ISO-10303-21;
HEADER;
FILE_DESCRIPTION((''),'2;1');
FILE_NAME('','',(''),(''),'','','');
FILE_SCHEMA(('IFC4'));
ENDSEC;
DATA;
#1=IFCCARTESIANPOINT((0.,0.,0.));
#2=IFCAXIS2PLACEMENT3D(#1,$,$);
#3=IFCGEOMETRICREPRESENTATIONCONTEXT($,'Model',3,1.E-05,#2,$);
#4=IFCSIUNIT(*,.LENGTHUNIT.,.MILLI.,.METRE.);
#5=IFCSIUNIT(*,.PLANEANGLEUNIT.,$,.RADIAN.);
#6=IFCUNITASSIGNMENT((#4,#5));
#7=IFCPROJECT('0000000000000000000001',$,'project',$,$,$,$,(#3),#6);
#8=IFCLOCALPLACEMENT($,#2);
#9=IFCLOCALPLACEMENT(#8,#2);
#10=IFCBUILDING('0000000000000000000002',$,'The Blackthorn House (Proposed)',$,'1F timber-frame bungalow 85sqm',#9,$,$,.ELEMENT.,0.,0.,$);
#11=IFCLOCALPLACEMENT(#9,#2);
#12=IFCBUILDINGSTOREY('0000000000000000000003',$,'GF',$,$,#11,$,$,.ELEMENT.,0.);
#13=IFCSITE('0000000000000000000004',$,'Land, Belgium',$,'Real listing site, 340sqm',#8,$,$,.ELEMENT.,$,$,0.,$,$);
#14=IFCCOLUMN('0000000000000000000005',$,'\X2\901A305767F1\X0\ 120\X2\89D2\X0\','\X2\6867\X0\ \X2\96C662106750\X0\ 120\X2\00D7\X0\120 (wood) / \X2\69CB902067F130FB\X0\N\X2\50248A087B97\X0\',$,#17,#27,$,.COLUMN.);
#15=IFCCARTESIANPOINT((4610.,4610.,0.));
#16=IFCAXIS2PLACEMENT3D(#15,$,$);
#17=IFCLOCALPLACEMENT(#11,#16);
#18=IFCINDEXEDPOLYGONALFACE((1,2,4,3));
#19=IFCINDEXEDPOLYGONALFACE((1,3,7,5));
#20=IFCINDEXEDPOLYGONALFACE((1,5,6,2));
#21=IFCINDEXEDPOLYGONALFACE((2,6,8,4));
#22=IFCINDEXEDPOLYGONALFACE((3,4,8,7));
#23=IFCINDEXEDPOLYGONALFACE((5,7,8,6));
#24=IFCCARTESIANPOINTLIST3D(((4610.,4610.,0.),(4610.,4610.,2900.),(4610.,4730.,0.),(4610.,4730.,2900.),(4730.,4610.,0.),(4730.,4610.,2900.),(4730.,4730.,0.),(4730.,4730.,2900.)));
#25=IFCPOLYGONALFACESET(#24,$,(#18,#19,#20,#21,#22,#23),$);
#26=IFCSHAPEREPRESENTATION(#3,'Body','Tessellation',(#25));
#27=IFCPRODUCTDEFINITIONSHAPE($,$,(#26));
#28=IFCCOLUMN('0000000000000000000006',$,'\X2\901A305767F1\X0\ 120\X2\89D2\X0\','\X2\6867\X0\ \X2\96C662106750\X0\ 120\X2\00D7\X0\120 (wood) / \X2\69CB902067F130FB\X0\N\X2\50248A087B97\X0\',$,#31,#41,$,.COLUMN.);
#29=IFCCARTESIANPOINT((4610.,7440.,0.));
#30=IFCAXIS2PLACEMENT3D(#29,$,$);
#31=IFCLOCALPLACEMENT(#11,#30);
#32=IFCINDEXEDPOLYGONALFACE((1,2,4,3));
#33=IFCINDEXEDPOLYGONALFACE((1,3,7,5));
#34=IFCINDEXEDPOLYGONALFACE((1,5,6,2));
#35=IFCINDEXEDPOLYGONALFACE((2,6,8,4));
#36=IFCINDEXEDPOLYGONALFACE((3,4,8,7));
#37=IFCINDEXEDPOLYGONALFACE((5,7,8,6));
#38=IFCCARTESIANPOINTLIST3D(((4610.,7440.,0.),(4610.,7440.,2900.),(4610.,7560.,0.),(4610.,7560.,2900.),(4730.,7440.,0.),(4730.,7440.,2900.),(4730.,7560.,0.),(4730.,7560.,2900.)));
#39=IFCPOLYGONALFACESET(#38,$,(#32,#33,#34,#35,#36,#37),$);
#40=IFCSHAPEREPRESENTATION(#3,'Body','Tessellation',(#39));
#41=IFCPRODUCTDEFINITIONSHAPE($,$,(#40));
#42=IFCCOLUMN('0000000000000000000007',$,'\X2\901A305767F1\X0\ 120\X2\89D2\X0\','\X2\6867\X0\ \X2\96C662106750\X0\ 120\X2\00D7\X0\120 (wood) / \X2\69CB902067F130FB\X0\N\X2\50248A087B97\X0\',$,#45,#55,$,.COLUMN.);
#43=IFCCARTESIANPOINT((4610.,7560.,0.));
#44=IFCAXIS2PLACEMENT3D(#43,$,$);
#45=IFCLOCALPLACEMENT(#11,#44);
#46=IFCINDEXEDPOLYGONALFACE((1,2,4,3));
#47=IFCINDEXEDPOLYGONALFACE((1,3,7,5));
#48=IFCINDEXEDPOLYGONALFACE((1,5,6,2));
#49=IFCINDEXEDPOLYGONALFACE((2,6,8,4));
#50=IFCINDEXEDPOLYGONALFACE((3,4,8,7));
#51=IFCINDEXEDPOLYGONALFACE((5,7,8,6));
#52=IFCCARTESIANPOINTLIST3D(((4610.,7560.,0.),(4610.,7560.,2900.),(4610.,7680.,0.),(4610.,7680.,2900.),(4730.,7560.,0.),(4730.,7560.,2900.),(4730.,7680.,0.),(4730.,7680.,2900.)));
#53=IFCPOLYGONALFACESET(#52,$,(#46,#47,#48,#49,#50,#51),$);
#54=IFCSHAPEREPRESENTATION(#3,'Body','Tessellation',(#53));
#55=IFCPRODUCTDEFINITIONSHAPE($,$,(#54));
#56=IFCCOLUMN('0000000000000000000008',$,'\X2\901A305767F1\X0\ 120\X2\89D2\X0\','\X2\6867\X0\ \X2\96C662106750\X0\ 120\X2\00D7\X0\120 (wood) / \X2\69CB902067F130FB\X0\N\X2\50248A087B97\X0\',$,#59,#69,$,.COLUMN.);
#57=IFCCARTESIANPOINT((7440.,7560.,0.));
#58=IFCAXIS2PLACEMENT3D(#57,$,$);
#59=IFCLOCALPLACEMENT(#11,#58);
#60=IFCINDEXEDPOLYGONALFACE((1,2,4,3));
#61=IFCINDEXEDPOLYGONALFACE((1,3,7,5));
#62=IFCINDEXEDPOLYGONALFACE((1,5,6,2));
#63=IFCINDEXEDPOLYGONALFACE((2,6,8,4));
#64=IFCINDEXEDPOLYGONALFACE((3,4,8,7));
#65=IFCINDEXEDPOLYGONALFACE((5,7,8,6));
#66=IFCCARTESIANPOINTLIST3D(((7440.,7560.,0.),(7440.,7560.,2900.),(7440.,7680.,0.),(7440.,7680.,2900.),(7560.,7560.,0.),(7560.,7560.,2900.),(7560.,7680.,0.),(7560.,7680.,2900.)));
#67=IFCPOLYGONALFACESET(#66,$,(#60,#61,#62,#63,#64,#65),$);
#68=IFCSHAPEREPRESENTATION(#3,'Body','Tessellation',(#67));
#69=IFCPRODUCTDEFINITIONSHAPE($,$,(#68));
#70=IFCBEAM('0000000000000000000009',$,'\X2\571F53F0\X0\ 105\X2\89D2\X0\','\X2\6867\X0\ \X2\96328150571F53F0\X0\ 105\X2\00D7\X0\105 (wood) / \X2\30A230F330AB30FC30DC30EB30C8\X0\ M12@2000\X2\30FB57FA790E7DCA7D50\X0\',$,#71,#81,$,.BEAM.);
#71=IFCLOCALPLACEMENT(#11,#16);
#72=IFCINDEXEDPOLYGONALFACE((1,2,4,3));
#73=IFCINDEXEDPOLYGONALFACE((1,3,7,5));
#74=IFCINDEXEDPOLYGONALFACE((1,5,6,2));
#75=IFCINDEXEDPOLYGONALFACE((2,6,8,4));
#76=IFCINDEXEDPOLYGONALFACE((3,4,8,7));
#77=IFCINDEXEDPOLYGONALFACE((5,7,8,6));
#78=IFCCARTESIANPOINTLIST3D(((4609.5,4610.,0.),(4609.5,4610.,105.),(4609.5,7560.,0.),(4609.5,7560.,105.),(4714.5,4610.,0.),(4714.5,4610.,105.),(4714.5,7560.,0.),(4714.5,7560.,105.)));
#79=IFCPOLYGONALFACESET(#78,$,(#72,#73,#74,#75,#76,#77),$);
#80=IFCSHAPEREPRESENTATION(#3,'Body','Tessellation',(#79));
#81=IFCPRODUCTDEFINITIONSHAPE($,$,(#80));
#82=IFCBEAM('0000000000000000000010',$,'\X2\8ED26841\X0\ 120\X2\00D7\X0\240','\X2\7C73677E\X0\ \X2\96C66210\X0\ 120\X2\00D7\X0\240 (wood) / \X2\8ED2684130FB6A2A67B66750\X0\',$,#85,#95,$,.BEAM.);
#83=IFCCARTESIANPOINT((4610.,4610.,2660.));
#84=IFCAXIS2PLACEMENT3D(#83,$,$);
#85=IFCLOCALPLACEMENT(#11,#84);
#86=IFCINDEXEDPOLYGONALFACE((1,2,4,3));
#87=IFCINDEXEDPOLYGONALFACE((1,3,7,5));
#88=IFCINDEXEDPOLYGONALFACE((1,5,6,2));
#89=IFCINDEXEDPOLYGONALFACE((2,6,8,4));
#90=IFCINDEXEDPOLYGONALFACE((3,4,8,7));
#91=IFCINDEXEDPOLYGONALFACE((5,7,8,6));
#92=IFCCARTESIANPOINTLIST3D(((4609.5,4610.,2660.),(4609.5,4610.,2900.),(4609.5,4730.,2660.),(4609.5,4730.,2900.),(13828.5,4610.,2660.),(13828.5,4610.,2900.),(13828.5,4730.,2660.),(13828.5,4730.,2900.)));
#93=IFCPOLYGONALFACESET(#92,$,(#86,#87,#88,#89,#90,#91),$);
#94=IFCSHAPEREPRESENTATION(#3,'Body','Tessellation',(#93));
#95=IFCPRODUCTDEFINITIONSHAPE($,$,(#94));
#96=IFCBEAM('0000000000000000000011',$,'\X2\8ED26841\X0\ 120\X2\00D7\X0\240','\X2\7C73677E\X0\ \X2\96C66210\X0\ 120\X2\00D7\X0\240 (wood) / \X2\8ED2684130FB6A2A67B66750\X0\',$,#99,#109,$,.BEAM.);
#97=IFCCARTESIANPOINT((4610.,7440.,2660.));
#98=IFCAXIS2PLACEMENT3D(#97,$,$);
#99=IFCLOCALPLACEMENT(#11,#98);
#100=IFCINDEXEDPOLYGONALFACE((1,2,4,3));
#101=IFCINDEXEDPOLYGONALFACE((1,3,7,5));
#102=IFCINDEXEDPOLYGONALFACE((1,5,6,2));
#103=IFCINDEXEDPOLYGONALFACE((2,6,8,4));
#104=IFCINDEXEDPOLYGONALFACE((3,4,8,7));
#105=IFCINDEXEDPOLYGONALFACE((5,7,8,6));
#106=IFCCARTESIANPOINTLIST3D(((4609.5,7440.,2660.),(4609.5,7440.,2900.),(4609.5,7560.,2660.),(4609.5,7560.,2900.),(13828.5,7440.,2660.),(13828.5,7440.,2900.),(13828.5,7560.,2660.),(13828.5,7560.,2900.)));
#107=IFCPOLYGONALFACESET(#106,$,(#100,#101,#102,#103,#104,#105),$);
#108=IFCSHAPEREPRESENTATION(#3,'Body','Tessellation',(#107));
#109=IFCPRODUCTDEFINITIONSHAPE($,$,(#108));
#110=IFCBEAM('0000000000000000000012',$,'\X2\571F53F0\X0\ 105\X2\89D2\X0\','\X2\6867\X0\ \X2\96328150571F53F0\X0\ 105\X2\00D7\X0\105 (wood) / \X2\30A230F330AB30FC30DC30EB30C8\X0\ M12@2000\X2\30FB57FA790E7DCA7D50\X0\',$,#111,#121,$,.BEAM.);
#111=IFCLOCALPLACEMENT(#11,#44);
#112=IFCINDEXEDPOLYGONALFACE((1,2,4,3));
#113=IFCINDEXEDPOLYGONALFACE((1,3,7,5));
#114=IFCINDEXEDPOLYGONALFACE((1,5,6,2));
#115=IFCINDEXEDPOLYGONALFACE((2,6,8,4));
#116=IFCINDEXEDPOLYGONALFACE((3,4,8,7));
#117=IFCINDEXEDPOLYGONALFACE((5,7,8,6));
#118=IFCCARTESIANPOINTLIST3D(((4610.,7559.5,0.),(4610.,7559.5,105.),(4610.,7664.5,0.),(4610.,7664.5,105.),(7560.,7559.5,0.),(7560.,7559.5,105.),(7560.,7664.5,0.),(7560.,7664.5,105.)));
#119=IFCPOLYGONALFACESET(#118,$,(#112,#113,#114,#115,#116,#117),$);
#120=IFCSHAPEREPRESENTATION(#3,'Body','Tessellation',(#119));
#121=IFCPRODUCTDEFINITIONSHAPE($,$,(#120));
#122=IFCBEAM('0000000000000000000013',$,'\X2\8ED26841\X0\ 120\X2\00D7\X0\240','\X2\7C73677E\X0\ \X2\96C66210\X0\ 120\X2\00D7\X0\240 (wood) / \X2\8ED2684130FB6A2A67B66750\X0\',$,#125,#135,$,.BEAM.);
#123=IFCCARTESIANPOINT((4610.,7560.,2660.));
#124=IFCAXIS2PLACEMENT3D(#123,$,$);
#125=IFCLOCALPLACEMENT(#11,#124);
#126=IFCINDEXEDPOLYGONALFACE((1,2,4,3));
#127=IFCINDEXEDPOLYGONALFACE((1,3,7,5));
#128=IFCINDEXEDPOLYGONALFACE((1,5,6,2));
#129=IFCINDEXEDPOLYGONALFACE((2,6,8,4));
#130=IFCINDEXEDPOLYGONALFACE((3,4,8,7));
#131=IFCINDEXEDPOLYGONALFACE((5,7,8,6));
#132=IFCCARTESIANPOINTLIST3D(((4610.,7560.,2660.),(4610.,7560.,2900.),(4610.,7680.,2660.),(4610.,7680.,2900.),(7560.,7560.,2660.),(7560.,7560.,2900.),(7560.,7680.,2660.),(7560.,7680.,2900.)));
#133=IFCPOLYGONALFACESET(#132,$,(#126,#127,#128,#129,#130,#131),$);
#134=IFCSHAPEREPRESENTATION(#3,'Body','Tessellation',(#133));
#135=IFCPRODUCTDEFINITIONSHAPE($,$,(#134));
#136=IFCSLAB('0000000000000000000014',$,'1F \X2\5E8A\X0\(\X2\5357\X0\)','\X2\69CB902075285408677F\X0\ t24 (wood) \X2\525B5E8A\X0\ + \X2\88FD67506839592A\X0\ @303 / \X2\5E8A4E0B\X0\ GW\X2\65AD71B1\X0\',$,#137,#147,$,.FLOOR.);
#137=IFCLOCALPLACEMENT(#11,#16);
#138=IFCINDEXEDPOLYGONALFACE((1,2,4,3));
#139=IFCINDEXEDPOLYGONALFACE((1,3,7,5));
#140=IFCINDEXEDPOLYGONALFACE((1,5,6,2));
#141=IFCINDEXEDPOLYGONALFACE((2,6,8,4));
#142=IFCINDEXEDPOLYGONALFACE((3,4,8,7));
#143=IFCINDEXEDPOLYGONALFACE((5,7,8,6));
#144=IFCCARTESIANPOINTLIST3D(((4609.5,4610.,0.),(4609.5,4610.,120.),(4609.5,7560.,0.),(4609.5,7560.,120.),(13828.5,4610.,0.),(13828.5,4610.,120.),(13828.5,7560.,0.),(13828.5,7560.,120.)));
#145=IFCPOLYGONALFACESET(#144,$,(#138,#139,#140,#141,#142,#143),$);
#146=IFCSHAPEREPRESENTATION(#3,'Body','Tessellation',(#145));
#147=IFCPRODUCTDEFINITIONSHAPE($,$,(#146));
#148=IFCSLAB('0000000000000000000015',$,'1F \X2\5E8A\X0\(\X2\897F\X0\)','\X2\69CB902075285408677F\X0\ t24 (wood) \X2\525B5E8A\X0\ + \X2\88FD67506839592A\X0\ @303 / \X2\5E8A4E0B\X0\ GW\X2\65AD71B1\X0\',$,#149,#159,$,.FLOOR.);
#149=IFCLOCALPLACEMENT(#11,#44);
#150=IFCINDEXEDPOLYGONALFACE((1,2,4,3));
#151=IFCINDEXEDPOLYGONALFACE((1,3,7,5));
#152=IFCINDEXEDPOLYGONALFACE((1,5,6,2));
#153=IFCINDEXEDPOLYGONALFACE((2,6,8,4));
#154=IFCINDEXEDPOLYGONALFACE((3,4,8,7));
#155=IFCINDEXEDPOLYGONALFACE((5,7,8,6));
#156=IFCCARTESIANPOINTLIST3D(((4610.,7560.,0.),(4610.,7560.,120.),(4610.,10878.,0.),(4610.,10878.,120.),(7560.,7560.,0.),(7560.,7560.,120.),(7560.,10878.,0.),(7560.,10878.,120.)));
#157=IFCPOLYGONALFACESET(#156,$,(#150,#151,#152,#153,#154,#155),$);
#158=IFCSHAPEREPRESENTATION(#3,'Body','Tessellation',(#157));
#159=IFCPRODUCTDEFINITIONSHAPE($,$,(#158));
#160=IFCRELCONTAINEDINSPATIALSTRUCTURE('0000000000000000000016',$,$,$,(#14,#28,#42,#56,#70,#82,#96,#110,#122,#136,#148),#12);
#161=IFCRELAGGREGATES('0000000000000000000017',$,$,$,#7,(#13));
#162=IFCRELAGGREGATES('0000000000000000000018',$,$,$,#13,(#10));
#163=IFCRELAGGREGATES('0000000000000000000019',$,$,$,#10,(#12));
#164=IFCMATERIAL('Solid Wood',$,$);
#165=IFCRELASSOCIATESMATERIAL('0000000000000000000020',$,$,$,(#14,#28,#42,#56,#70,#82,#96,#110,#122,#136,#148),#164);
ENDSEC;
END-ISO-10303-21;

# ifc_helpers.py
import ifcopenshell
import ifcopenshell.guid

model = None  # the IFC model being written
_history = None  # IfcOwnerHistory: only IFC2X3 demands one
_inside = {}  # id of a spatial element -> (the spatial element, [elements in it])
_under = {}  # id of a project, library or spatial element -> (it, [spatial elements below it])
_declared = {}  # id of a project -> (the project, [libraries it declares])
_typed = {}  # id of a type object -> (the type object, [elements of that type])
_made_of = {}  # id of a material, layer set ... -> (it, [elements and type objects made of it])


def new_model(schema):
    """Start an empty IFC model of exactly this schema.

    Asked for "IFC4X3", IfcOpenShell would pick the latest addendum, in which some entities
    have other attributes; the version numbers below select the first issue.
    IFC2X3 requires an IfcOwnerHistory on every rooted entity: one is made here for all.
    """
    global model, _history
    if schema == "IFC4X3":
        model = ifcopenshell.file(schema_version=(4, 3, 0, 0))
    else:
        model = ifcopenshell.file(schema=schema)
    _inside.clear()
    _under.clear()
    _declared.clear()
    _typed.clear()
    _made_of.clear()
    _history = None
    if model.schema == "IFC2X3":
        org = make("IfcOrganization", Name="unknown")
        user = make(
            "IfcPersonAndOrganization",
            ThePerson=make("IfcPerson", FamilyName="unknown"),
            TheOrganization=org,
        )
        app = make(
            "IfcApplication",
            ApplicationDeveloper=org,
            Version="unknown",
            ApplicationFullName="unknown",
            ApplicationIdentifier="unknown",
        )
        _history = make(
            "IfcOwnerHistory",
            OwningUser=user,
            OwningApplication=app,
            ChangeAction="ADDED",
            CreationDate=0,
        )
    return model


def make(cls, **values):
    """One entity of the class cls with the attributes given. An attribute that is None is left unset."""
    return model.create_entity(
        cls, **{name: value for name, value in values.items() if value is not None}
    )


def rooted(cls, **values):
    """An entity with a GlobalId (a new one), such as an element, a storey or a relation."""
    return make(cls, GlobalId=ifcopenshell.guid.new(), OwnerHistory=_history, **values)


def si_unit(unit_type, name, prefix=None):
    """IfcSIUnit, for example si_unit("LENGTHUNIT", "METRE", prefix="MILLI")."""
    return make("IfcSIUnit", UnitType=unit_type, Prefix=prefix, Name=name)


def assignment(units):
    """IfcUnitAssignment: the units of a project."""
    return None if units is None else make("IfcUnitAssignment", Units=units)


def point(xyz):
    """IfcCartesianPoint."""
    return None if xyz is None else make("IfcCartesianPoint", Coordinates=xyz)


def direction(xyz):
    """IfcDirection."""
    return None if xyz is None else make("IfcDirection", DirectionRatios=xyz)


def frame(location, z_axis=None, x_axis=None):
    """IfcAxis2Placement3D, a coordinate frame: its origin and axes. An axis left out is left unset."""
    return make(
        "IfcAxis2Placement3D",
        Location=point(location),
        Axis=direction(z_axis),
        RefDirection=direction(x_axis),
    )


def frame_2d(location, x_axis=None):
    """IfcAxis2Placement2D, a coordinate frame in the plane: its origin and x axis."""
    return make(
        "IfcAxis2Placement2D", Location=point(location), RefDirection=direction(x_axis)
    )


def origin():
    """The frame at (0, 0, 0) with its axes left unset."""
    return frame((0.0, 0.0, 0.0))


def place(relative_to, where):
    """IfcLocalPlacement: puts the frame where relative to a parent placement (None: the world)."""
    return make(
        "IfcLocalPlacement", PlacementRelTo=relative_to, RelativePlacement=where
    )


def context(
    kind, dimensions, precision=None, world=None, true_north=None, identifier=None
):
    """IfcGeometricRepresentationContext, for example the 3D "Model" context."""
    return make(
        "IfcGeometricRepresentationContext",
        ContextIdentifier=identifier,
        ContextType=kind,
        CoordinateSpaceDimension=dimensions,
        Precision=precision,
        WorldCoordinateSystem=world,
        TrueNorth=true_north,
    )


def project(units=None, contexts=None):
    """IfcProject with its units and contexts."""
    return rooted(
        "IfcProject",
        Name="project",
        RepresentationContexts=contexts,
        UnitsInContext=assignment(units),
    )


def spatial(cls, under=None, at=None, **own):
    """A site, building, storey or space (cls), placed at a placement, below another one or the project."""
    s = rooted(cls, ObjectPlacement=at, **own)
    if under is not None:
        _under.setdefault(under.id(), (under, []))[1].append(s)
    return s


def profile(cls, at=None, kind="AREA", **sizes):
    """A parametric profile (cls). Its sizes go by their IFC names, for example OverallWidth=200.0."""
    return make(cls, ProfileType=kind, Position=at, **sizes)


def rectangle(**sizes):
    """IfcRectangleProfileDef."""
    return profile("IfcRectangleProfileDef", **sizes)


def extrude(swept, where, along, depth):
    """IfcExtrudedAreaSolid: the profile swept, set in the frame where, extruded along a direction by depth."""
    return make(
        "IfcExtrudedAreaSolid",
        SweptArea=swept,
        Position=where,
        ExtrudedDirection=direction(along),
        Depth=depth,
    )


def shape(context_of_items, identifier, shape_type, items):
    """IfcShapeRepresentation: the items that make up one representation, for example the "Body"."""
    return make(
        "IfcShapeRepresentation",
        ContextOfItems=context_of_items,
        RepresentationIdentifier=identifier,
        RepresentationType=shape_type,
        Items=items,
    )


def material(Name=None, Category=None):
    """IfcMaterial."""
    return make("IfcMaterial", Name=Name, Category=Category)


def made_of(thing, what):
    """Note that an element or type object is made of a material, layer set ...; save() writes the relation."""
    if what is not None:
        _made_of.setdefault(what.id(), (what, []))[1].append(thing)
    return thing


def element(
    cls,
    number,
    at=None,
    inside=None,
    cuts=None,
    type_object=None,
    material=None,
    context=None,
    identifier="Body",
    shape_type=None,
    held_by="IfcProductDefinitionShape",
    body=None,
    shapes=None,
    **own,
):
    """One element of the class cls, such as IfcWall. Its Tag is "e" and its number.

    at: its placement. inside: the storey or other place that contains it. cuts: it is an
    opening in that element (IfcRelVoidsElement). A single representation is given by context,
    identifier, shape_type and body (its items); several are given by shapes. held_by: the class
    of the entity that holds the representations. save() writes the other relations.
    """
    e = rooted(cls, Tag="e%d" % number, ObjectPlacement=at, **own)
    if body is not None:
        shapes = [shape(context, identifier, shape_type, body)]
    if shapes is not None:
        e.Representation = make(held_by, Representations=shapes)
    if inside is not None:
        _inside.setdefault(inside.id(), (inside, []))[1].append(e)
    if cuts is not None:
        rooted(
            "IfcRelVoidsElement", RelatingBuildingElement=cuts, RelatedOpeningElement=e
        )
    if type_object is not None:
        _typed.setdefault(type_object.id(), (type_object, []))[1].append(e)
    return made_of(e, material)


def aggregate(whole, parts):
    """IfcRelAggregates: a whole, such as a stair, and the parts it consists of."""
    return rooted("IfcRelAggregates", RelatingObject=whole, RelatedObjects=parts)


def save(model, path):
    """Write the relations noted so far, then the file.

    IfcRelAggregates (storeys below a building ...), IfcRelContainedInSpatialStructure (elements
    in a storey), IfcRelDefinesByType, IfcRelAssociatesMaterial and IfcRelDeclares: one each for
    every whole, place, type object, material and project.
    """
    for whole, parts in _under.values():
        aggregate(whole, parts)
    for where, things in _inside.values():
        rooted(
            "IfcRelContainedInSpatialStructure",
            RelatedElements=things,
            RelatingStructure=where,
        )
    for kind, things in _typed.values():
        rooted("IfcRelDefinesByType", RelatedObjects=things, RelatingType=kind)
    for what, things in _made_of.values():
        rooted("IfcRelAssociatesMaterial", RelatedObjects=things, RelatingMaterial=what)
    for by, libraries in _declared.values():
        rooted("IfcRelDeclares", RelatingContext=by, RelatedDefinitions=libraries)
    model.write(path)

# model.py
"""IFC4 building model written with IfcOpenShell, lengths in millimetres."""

from ifc_helpers import new_model, si_unit, frame, frame_2d, origin, place, context, project, spatial, rectangle, extrude, material, element, save


model = new_model("IFC4")

# Units and contexts
model_context = context("Model", 3, precision=1e-05, world=origin())
ifc_project = project(units=[si_unit("LENGTHUNIT", "METRE", prefix="MILLI"), si_unit("PLANEANGLEUNIT", "RADIAN")], contexts=[model_context])

# Site, building, storey
site_placement = place(None, origin())
site = spatial("IfcSite", under=ifc_project, at=site_placement, Name="Land, Belgium", ObjectType="Real listing site, 340sqm", CompositionType="ELEMENT", RefElevation=0.0)
building_placement = place(site_placement, origin())
building = spatial("IfcBuilding", under=site, at=building_placement, Name="The Blackthorn House (Proposed)", ObjectType="1F timber-frame bungalow 85sqm", CompositionType="ELEMENT", ElevationOfRefHeight=0.0, ElevationOfTerrain=0.0)
storey_placement = place(building_placement, origin())
storey = spatial("IfcBuildingStorey", under=building, at=storey_placement, Name="GF", CompositionType="ELEMENT", Elevation=0.0)

# Columns
ifc_material_1 = material(Name="Solid Wood")
column_1_placement = place(storey_placement, frame((4610.0, 4610.0, 0.0)))
element("IfcColumn", 1, at=column_1_placement, inside=storey, material=ifc_material_1, Name="通し柱 120角", Description="桧 集成材 120×120 (wood) / 構造柱・N値計算", PredefinedType="COLUMN", context=model_context, shape_type="SweptSolid", body=[
    extrude(rectangle(XDim=120.0, YDim=120.0, at=frame_2d((60.0, 60.0))), frame((4610.0, 4610.0, 0.0)), (0.0, 0.0, 1.0), 2900.0),
])
column_2_placement = place(storey_placement, frame((4610.0, 7440.0, 0.0)))
element("IfcColumn", 2, at=column_2_placement, inside=storey, material=ifc_material_1, Name="通し柱 120角", Description="桧 集成材 120×120 (wood) / 構造柱・N値計算", PredefinedType="COLUMN", context=model_context, shape_type="SweptSolid", body=[
    extrude(rectangle(XDim=120.0, YDim=120.0, at=frame_2d((60.0, 60.0))), frame((4610.0, 7440.0, 0.0)), (0.0, 0.0, 1.0), 2900.0),
])
column_3_placement = place(storey_placement, frame((4610.0, 7560.0, 0.0)))
element("IfcColumn", 3, at=column_3_placement, inside=storey, material=ifc_material_1, Name="通し柱 120角", Description="桧 集成材 120×120 (wood) / 構造柱・N値計算", PredefinedType="COLUMN", context=model_context, shape_type="SweptSolid", body=[
    extrude(rectangle(XDim=120.0, YDim=120.0, at=frame_2d((60.0, 60.0))), frame((4610.0, 7560.0, 0.0)), (0.0, 0.0, 1.0), 2900.0),
])
column_4_placement = place(storey_placement, frame((7440.0, 7560.0, 0.0)))
element("IfcColumn", 4, at=column_4_placement, inside=storey, material=ifc_material_1, Name="通し柱 120角", Description="桧 集成材 120×120 (wood) / 構造柱・N値計算", PredefinedType="COLUMN", context=model_context, shape_type="SweptSolid", body=[
    extrude(rectangle(XDim=120.0, YDim=120.0, at=frame_2d((60.0, 60.0))), frame((7440.0, 7560.0, 0.0)), (0.0, 0.0, 1.0), 2900.0),
])

# Beams
beam_1_placement = place(storey_placement, frame((4610.0, 4610.0, 0.0)))
element("IfcBeam", 5, at=beam_1_placement, inside=storey, material=ifc_material_1, Name="土台 105角", Description="桧 防腐土台 105×105 (wood) / アンカーボルト M12@2000・基礎緊結", PredefinedType="BEAM", context=model_context, shape_type="SweptSolid", body=[
    extrude(rectangle(XDim=105.0, YDim=2950.0, at=frame_2d((52.0, 1475.0))), frame((4610.0, 4610.0, 0.0)), (0.0, 0.0, 1.0), 105.0),
])
beam_2_placement = place(storey_placement, frame((4610.0, 4610.0, 2660.0)))
element("IfcBeam", 6, at=beam_2_placement, inside=storey, material=ifc_material_1, Name="軒桁 120×240", Description="米松 集成 120×240 (wood) / 軒桁・横架材", PredefinedType="BEAM", context=model_context, shape_type="SweptSolid", body=[
    extrude(rectangle(XDim=9219.0, YDim=120.0, at=frame_2d((4609.0, 60.0))), frame((4610.0, 4610.0, 2660.0)), (0.0, 0.0, 1.0), 240.0),
])
beam_3_placement = place(storey_placement, frame((4610.0, 7440.0, 2660.0)))
element("IfcBeam", 7, at=beam_3_placement, inside=storey, material=ifc_material_1, Name="軒桁 120×240", Description="米松 集成 120×240 (wood) / 軒桁・横架材", PredefinedType="BEAM", context=model_context, shape_type="SweptSolid", body=[
    extrude(rectangle(XDim=9219.0, YDim=120.0, at=frame_2d((4609.0, 60.0))), frame((4610.0, 7440.0, 2660.0)), (0.0, 0.0, 1.0), 240.0),
])
beam_4_placement = place(storey_placement, frame((4610.0, 7560.0, 0.0)))
element("IfcBeam", 8, at=beam_4_placement, inside=storey, material=ifc_material_1, Name="土台 105角", Description="桧 防腐土台 105×105 (wood) / アンカーボルト M12@2000・基礎緊結", PredefinedType="BEAM", context=model_context, shape_type="SweptSolid", body=[
    extrude(rectangle(XDim=2950.0, YDim=105.0, at=frame_2d((1475.0, 52.0))), frame((4610.0, 7560.0, 0.0)), (0.0, 0.0, 1.0), 105.0),
])
beam_5_placement = place(storey_placement, frame((4610.0, 7560.0, 2660.0)))
element("IfcBeam", 9, at=beam_5_placement, inside=storey, material=ifc_material_1, Name="軒桁 120×240", Description="米松 集成 120×240 (wood) / 軒桁・横架材", PredefinedType="BEAM", context=model_context, shape_type="SweptSolid", body=[
    extrude(rectangle(XDim=2950.0, YDim=120.0, at=frame_2d((1475.0, 60.0))), frame((4610.0, 7560.0, 2660.0)), (0.0, 0.0, 1.0), 240.0),
])

# Slabs
slab_1_placement = place(storey_placement, frame((4610.0, 4610.0, 0.0)))
element("IfcSlab", 10, at=slab_1_placement, inside=storey, material=ifc_material_1, Name="1F 床(南)", Description="構造用合板 t24 (wood) 剛床 + 製材根太 @303 / 床下 GW断熱", PredefinedType="FLOOR", context=model_context, shape_type="SweptSolid", body=[
    extrude(rectangle(XDim=9219.0, YDim=2950.0, at=frame_2d((4609.0, 1475.0))), frame((4610.0, 4610.0, 0.0)), (0.0, 0.0, 1.0), 120.0),
])
slab_2_placement = place(storey_placement, frame((4610.0, 7560.0, 0.0)))
element("IfcSlab", 11, at=slab_2_placement, inside=storey, material=ifc_material_1, Name="1F 床(西)", Description="構造用合板 t24 (wood) 剛床 + 製材根太 @303 / 床下 GW断熱", PredefinedType="FLOOR", context=model_context, shape_type="SweptSolid", body=[
    extrude(rectangle(XDim=2950.0, YDim=3318.0, at=frame_2d((1475.0, 1659.0))), frame((4610.0, 7560.0, 0.0)), (0.0, 0.0, 1.0), 120.0),
])

save(model, "model.ifc")
